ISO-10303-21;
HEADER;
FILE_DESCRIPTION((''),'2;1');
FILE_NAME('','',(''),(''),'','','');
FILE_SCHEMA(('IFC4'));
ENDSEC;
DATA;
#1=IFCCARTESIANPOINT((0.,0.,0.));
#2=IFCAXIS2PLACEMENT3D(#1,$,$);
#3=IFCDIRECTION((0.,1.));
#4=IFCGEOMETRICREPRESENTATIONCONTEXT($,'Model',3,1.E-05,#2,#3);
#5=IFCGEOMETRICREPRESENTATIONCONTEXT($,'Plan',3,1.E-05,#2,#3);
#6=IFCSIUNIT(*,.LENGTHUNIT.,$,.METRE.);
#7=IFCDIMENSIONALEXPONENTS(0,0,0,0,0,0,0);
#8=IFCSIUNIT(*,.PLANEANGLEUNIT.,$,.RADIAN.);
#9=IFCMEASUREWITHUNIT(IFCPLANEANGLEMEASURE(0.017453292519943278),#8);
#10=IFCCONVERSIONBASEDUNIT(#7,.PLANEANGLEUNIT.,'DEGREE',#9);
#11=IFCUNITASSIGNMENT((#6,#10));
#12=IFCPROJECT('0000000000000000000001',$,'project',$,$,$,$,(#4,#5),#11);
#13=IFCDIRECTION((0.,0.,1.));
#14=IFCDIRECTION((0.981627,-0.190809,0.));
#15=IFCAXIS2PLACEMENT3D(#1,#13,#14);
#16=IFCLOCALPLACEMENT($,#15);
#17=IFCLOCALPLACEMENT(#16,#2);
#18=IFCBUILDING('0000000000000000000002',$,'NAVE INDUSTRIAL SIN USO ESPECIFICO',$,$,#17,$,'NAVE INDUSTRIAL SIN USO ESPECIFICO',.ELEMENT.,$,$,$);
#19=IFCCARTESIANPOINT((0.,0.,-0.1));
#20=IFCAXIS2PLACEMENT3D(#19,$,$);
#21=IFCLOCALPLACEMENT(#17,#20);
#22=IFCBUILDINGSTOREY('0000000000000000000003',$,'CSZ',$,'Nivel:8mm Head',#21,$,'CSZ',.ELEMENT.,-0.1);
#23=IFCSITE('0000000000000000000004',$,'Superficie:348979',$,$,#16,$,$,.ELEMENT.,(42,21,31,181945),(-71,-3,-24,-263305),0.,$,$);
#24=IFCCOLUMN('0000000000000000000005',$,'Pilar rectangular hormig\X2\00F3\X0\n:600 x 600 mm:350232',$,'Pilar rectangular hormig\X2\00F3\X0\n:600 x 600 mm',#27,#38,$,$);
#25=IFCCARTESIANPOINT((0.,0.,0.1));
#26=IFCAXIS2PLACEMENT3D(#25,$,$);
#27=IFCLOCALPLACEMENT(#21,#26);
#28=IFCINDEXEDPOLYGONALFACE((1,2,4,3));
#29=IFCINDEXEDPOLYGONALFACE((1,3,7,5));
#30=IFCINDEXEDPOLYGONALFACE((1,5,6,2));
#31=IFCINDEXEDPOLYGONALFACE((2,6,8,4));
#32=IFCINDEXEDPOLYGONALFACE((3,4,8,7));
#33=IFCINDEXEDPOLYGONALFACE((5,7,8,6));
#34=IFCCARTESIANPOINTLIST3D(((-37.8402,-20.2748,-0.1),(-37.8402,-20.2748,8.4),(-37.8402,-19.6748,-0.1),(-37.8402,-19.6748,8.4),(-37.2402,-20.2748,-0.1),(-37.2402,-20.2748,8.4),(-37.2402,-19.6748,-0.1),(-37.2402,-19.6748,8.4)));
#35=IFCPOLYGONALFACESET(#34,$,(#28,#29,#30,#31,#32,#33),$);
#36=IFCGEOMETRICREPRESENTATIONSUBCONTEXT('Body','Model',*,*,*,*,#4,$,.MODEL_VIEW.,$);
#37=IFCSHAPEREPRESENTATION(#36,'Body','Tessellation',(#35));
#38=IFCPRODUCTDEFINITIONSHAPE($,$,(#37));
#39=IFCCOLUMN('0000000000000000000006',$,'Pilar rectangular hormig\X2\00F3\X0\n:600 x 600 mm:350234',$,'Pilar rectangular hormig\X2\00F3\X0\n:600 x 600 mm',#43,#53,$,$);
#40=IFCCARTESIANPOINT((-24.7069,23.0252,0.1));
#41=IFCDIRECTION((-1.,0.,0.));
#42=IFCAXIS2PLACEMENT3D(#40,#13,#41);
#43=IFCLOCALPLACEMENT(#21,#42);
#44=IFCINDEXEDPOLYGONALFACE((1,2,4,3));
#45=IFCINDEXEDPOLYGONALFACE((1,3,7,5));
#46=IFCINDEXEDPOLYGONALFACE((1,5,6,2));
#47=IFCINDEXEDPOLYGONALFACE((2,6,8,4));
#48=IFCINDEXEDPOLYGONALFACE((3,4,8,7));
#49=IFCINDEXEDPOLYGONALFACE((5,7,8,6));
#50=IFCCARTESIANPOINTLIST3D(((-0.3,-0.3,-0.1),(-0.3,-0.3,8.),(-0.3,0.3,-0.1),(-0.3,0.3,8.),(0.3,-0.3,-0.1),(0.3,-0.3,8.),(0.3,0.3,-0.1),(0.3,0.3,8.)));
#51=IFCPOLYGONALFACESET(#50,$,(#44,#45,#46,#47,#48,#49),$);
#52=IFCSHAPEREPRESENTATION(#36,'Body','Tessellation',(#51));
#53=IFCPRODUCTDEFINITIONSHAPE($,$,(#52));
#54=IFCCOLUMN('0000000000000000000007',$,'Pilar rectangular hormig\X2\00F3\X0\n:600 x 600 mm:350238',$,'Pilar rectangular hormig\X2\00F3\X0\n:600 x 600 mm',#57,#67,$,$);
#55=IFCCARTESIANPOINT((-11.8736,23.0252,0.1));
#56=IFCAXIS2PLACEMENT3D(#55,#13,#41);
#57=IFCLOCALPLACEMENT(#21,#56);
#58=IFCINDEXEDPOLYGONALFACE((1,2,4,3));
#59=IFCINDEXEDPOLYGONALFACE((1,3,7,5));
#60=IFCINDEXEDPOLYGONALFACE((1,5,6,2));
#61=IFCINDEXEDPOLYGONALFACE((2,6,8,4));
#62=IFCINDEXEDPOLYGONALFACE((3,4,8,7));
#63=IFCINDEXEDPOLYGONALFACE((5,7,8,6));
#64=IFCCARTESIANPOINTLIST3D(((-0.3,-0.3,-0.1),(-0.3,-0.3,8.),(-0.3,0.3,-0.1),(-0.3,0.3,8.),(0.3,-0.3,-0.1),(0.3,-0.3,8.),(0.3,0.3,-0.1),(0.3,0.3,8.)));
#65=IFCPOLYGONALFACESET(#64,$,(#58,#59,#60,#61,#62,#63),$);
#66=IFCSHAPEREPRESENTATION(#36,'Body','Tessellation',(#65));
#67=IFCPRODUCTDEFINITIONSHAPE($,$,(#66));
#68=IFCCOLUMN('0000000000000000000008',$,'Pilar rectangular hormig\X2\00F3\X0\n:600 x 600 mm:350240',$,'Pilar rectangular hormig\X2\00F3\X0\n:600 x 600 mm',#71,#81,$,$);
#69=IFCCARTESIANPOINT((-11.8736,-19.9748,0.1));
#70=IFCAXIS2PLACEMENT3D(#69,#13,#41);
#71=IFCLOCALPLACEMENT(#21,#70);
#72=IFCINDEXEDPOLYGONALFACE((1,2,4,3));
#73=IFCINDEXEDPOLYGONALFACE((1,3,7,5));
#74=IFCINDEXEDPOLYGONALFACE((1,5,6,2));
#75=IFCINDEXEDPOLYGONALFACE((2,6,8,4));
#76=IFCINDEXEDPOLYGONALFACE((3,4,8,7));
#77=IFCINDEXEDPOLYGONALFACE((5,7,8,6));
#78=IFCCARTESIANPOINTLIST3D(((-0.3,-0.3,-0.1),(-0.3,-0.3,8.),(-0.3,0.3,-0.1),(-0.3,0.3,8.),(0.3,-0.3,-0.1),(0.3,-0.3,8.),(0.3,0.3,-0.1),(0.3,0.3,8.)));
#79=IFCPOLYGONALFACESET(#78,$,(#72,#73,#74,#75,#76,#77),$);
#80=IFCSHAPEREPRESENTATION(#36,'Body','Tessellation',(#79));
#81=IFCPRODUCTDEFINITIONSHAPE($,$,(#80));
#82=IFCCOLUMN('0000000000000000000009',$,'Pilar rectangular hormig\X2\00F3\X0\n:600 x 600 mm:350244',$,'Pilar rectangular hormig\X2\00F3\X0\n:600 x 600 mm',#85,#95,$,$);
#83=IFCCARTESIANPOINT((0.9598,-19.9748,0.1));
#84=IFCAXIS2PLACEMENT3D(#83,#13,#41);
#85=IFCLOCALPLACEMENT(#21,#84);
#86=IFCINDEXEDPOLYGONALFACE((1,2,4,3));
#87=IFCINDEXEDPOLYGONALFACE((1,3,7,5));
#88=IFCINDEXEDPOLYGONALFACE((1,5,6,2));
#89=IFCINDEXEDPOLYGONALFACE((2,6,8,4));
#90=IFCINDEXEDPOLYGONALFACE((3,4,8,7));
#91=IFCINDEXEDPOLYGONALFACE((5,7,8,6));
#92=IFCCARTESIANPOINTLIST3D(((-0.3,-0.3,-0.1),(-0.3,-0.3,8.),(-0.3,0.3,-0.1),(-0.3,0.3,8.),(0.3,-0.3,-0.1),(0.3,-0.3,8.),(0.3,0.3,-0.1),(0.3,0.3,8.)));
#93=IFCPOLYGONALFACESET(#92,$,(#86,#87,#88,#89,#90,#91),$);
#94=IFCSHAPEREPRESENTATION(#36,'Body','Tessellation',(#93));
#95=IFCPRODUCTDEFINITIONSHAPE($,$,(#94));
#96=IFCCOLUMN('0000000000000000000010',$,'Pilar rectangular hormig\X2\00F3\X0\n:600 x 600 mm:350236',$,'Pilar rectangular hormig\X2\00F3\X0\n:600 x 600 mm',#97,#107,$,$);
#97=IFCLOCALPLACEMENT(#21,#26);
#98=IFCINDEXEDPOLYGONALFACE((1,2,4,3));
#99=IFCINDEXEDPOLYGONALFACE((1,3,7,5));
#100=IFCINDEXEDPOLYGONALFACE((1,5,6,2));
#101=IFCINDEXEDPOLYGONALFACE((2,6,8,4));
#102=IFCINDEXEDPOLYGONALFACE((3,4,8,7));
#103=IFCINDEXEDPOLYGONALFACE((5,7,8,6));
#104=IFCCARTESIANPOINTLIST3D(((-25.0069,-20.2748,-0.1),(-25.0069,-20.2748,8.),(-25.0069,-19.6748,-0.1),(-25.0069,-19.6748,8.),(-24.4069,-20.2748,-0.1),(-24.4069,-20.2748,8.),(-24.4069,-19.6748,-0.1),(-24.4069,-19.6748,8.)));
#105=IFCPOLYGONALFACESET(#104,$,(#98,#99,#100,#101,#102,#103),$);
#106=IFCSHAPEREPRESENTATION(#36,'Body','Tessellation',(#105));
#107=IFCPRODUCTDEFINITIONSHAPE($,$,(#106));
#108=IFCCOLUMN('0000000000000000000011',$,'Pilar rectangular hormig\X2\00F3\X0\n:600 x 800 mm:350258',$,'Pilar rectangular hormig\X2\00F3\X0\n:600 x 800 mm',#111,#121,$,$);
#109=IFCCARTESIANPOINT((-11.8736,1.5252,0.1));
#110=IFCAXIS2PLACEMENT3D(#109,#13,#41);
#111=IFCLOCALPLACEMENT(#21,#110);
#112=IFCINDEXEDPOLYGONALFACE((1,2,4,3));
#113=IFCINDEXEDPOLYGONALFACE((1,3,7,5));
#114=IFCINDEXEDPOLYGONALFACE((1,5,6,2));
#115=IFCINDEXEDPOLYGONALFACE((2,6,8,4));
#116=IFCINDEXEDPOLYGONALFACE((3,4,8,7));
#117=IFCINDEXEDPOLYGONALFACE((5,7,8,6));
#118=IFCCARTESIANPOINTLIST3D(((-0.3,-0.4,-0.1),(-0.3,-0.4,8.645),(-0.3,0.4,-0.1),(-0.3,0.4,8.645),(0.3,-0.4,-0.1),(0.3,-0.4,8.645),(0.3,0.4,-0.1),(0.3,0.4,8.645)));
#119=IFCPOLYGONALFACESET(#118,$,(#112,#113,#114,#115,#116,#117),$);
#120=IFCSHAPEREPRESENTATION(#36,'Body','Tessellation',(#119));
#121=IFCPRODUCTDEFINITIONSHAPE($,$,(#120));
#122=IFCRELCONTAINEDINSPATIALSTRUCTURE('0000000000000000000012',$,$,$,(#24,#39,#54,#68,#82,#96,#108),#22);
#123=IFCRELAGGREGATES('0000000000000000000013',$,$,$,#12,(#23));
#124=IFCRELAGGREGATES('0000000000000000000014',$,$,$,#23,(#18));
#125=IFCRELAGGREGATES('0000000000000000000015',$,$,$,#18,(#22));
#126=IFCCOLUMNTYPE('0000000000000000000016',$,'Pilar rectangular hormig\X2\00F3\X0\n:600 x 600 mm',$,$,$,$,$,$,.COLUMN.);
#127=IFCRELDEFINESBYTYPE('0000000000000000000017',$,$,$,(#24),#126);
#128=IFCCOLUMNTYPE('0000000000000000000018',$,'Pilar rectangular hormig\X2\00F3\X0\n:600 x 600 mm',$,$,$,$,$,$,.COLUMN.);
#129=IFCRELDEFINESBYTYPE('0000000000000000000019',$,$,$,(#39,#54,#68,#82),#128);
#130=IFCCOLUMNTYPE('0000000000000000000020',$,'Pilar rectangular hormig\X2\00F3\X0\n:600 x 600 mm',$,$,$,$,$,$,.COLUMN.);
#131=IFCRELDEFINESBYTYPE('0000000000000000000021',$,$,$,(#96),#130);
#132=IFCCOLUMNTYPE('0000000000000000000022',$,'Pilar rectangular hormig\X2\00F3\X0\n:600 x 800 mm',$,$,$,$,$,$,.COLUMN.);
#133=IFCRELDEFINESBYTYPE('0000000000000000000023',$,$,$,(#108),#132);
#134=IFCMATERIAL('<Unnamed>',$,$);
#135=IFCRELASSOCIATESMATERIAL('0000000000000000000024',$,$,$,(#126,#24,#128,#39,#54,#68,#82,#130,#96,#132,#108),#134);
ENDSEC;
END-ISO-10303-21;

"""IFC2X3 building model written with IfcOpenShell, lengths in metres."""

from ifc_helpers import new_model, entity, si_unit, converted_unit, direction, frame, frame_2d, origin, origin_2d_with_axis, place, context, subcontext, project, spatial, rectangle, extrude, source, transform, mapped, material, type_object, type_shapes, element, save


model = new_model("IFC2X3")

# Units and contexts
model_context = context("Model", 3, precision=1e-05, world=origin(), true_north=direction((0.0, 1.0)))
plan_context = context("Plan", 3, precision=1e-05, world=origin(), true_north=direction((0.0, 1.0)))
body_context = subcontext(model_context, "Body", "Model", "MODEL_VIEW")
ifc_project = project(units=[si_unit("LENGTHUNIT", "METRE"), converted_unit("PLANEANGLEUNIT", "DEGREE", entity("IfcPlaneAngleMeasure", 0.017453292519943278), si_unit("PLANEANGLEUNIT", "RADIAN"), dimensions=[0, 0, 0, 0, 0, 0, 0])], contexts=[model_context, plan_context])

# Site, building, storey
site_placement = place(None, frame((0.0, 0.0, 0.0), z_axis=(0.0, 0.0, 1.0), x_axis=(0.981627, -0.190809, 0.0)))
site = spatial("IfcSite", under=ifc_project, at=site_placement, Name="Superficie:348979", CompositionType="ELEMENT", RefLatitude=(42, 21, 31, 181945), RefLongitude=(-71, -3, -24, -263305), RefElevation=0.0)
building_placement = place(site_placement, origin())
building = spatial("IfcBuilding", under=site, at=building_placement, Name="NAVE INDUSTRIAL SIN USO ESPECIFICO", LongName="NAVE INDUSTRIAL SIN USO ESPECIFICO", CompositionType="ELEMENT")
storey_placement = place(building_placement, frame((0.0, 0.0, -0.1)))
storey = spatial("IfcBuildingStorey", under=building, at=storey_placement, Name="CSZ", ObjectType="Nivel:8mm Head", LongName="CSZ", CompositionType="ELEMENT", Elevation=-0.1)

# Columns
ifc_material_1 = material(Name="<Unnamed>")
column_type_1 = type_object("IfcColumnType", Name="Pilar rectangular hormigón:600 x 600 mm", PredefinedType="COLUMN", material=ifc_material_1)
shared_shape_1 = source(origin(), body_context, "Body", "SweptSolid", [
    extrude(rectangle(XDim=0.6, YDim=0.6, at=frame_2d((0.0, 0.0), x_axis=(1.0, 0.0))), frame((-37.5402, -19.9748, -0.1)), (0.0, 0.0, 1.0), 8.5),
])
type_shapes(column_type_1, [shared_shape_1])
column_1_placement = place(storey_placement, frame((0.0, 0.0, 0.1)))
element("IfcColumn", 1, at=column_1_placement, inside=storey, type_object=column_type_1, material=ifc_material_1, Name="Pilar rectangular hormigón:600 x 600 mm:350232", ObjectType="Pilar rectangular hormigón:600 x 600 mm", context=body_context, shape_type="MappedRepresentation", body=[
    mapped(shared_shape_1, transform((0.0, 0.0, 0.0), scale=1.0)),
])
column_type_2 = type_object("IfcColumnType", Name="Pilar rectangular hormigón:600 x 600 mm", PredefinedType="COLUMN", material=ifc_material_1)
shared_shape_2 = source(origin(), body_context, "Body", "SweptSolid", [
    extrude(rectangle(XDim=0.6, YDim=0.6, at=origin_2d_with_axis()), frame((0.0, 0.0, -0.1), z_axis=(0.0, 0.0, 1.0), x_axis=(-1.0, 0.0, 0.0)), (0.0, 0.0, 1.0), 8.1),
])
type_shapes(column_type_2, [shared_shape_2])
for number, where, z_axis, x_axis, name in (
    (2, (-24.7069, 23.0252, 0.1), (0.0, 0.0, 1.0), (-1.0, 0.0, 0.0), "Pilar rectangular hormigón:600 x 600 mm:350234"),
    (3, (-11.8736, 23.0252, 0.1), (0.0, 0.0, 1.0), (-1.0, 0.0, 0.0), "Pilar rectangular hormigón:600 x 600 mm:350238"),
    (4, (-11.8736, -19.9748, 0.1), (0.0, 0.0, 1.0), (-1.0, 0.0, 0.0), "Pilar rectangular hormigón:600 x 600 mm:350240"),
    (5, (0.9598, -19.9748, 0.1), (0.0, 0.0, 1.0), (-1.0, 0.0, 0.0), "Pilar rectangular hormigón:600 x 600 mm:350244"),
):
    element("IfcColumn", number, at=place(storey_placement, frame(where, z_axis=z_axis, x_axis=x_axis)), inside=storey, type_object=column_type_2, material=ifc_material_1, Name=name, ObjectType="Pilar rectangular hormigón:600 x 600 mm", context=body_context, shape_type="MappedRepresentation", body=[
        mapped(shared_shape_2, transform((0.0, 0.0, 0.0), scale=1.0)),
    ])
column_type_3 = type_object("IfcColumnType", Name="Pilar rectangular hormigón:600 x 600 mm", PredefinedType="COLUMN", material=ifc_material_1)
shared_shape_3 = source(origin(), body_context, "Body", "SweptSolid", [
    extrude(rectangle(XDim=0.6, YDim=0.6, at=frame_2d((0.0, 0.0), x_axis=(1.0, 0.0))), frame((-24.7069, -19.9748, -0.1)), (0.0, 0.0, 1.0), 8.1),
])
type_shapes(column_type_3, [shared_shape_3])
column_2_placement = place(storey_placement, frame((0.0, 0.0, 0.1)))
element("IfcColumn", 6, at=column_2_placement, inside=storey, type_object=column_type_3, material=ifc_material_1, Name="Pilar rectangular hormigón:600 x 600 mm:350236", ObjectType="Pilar rectangular hormigón:600 x 600 mm", context=body_context, shape_type="MappedRepresentation", body=[
    mapped(shared_shape_3, transform((0.0, 0.0, 0.0), scale=1.0)),
])
column_type_4 = type_object("IfcColumnType", Name="Pilar rectangular hormigón:600 x 800 mm", PredefinedType="COLUMN", material=ifc_material_1)
shared_shape_4 = source(origin(), body_context, "Body", "SweptSolid", [
    extrude(rectangle(XDim=0.6, YDim=0.8, at=origin_2d_with_axis()), frame((0.0, 0.0, -0.1), z_axis=(0.0, 0.0, 1.0), x_axis=(-1.0, 0.0, 0.0)), (0.0, 0.0, 1.0), 8.745),
])
type_shapes(column_type_4, [shared_shape_4])
column_3_placement = place(storey_placement, frame((-11.8736, 1.5252, 0.1), z_axis=(0.0, 0.0, 1.0), x_axis=(-1.0, 0.0, 0.0)))
element("IfcColumn", 7, at=column_3_placement, inside=storey, type_object=column_type_4, material=ifc_material_1, Name="Pilar rectangular hormigón:600 x 800 mm:350258", ObjectType="Pilar rectangular hormigón:600 x 800 mm", context=body_context, shape_type="MappedRepresentation", body=[
    mapped(shared_shape_4, transform((0.0, 0.0, 0.0), scale=1.0)),
])

save(model, "model.ifc")
